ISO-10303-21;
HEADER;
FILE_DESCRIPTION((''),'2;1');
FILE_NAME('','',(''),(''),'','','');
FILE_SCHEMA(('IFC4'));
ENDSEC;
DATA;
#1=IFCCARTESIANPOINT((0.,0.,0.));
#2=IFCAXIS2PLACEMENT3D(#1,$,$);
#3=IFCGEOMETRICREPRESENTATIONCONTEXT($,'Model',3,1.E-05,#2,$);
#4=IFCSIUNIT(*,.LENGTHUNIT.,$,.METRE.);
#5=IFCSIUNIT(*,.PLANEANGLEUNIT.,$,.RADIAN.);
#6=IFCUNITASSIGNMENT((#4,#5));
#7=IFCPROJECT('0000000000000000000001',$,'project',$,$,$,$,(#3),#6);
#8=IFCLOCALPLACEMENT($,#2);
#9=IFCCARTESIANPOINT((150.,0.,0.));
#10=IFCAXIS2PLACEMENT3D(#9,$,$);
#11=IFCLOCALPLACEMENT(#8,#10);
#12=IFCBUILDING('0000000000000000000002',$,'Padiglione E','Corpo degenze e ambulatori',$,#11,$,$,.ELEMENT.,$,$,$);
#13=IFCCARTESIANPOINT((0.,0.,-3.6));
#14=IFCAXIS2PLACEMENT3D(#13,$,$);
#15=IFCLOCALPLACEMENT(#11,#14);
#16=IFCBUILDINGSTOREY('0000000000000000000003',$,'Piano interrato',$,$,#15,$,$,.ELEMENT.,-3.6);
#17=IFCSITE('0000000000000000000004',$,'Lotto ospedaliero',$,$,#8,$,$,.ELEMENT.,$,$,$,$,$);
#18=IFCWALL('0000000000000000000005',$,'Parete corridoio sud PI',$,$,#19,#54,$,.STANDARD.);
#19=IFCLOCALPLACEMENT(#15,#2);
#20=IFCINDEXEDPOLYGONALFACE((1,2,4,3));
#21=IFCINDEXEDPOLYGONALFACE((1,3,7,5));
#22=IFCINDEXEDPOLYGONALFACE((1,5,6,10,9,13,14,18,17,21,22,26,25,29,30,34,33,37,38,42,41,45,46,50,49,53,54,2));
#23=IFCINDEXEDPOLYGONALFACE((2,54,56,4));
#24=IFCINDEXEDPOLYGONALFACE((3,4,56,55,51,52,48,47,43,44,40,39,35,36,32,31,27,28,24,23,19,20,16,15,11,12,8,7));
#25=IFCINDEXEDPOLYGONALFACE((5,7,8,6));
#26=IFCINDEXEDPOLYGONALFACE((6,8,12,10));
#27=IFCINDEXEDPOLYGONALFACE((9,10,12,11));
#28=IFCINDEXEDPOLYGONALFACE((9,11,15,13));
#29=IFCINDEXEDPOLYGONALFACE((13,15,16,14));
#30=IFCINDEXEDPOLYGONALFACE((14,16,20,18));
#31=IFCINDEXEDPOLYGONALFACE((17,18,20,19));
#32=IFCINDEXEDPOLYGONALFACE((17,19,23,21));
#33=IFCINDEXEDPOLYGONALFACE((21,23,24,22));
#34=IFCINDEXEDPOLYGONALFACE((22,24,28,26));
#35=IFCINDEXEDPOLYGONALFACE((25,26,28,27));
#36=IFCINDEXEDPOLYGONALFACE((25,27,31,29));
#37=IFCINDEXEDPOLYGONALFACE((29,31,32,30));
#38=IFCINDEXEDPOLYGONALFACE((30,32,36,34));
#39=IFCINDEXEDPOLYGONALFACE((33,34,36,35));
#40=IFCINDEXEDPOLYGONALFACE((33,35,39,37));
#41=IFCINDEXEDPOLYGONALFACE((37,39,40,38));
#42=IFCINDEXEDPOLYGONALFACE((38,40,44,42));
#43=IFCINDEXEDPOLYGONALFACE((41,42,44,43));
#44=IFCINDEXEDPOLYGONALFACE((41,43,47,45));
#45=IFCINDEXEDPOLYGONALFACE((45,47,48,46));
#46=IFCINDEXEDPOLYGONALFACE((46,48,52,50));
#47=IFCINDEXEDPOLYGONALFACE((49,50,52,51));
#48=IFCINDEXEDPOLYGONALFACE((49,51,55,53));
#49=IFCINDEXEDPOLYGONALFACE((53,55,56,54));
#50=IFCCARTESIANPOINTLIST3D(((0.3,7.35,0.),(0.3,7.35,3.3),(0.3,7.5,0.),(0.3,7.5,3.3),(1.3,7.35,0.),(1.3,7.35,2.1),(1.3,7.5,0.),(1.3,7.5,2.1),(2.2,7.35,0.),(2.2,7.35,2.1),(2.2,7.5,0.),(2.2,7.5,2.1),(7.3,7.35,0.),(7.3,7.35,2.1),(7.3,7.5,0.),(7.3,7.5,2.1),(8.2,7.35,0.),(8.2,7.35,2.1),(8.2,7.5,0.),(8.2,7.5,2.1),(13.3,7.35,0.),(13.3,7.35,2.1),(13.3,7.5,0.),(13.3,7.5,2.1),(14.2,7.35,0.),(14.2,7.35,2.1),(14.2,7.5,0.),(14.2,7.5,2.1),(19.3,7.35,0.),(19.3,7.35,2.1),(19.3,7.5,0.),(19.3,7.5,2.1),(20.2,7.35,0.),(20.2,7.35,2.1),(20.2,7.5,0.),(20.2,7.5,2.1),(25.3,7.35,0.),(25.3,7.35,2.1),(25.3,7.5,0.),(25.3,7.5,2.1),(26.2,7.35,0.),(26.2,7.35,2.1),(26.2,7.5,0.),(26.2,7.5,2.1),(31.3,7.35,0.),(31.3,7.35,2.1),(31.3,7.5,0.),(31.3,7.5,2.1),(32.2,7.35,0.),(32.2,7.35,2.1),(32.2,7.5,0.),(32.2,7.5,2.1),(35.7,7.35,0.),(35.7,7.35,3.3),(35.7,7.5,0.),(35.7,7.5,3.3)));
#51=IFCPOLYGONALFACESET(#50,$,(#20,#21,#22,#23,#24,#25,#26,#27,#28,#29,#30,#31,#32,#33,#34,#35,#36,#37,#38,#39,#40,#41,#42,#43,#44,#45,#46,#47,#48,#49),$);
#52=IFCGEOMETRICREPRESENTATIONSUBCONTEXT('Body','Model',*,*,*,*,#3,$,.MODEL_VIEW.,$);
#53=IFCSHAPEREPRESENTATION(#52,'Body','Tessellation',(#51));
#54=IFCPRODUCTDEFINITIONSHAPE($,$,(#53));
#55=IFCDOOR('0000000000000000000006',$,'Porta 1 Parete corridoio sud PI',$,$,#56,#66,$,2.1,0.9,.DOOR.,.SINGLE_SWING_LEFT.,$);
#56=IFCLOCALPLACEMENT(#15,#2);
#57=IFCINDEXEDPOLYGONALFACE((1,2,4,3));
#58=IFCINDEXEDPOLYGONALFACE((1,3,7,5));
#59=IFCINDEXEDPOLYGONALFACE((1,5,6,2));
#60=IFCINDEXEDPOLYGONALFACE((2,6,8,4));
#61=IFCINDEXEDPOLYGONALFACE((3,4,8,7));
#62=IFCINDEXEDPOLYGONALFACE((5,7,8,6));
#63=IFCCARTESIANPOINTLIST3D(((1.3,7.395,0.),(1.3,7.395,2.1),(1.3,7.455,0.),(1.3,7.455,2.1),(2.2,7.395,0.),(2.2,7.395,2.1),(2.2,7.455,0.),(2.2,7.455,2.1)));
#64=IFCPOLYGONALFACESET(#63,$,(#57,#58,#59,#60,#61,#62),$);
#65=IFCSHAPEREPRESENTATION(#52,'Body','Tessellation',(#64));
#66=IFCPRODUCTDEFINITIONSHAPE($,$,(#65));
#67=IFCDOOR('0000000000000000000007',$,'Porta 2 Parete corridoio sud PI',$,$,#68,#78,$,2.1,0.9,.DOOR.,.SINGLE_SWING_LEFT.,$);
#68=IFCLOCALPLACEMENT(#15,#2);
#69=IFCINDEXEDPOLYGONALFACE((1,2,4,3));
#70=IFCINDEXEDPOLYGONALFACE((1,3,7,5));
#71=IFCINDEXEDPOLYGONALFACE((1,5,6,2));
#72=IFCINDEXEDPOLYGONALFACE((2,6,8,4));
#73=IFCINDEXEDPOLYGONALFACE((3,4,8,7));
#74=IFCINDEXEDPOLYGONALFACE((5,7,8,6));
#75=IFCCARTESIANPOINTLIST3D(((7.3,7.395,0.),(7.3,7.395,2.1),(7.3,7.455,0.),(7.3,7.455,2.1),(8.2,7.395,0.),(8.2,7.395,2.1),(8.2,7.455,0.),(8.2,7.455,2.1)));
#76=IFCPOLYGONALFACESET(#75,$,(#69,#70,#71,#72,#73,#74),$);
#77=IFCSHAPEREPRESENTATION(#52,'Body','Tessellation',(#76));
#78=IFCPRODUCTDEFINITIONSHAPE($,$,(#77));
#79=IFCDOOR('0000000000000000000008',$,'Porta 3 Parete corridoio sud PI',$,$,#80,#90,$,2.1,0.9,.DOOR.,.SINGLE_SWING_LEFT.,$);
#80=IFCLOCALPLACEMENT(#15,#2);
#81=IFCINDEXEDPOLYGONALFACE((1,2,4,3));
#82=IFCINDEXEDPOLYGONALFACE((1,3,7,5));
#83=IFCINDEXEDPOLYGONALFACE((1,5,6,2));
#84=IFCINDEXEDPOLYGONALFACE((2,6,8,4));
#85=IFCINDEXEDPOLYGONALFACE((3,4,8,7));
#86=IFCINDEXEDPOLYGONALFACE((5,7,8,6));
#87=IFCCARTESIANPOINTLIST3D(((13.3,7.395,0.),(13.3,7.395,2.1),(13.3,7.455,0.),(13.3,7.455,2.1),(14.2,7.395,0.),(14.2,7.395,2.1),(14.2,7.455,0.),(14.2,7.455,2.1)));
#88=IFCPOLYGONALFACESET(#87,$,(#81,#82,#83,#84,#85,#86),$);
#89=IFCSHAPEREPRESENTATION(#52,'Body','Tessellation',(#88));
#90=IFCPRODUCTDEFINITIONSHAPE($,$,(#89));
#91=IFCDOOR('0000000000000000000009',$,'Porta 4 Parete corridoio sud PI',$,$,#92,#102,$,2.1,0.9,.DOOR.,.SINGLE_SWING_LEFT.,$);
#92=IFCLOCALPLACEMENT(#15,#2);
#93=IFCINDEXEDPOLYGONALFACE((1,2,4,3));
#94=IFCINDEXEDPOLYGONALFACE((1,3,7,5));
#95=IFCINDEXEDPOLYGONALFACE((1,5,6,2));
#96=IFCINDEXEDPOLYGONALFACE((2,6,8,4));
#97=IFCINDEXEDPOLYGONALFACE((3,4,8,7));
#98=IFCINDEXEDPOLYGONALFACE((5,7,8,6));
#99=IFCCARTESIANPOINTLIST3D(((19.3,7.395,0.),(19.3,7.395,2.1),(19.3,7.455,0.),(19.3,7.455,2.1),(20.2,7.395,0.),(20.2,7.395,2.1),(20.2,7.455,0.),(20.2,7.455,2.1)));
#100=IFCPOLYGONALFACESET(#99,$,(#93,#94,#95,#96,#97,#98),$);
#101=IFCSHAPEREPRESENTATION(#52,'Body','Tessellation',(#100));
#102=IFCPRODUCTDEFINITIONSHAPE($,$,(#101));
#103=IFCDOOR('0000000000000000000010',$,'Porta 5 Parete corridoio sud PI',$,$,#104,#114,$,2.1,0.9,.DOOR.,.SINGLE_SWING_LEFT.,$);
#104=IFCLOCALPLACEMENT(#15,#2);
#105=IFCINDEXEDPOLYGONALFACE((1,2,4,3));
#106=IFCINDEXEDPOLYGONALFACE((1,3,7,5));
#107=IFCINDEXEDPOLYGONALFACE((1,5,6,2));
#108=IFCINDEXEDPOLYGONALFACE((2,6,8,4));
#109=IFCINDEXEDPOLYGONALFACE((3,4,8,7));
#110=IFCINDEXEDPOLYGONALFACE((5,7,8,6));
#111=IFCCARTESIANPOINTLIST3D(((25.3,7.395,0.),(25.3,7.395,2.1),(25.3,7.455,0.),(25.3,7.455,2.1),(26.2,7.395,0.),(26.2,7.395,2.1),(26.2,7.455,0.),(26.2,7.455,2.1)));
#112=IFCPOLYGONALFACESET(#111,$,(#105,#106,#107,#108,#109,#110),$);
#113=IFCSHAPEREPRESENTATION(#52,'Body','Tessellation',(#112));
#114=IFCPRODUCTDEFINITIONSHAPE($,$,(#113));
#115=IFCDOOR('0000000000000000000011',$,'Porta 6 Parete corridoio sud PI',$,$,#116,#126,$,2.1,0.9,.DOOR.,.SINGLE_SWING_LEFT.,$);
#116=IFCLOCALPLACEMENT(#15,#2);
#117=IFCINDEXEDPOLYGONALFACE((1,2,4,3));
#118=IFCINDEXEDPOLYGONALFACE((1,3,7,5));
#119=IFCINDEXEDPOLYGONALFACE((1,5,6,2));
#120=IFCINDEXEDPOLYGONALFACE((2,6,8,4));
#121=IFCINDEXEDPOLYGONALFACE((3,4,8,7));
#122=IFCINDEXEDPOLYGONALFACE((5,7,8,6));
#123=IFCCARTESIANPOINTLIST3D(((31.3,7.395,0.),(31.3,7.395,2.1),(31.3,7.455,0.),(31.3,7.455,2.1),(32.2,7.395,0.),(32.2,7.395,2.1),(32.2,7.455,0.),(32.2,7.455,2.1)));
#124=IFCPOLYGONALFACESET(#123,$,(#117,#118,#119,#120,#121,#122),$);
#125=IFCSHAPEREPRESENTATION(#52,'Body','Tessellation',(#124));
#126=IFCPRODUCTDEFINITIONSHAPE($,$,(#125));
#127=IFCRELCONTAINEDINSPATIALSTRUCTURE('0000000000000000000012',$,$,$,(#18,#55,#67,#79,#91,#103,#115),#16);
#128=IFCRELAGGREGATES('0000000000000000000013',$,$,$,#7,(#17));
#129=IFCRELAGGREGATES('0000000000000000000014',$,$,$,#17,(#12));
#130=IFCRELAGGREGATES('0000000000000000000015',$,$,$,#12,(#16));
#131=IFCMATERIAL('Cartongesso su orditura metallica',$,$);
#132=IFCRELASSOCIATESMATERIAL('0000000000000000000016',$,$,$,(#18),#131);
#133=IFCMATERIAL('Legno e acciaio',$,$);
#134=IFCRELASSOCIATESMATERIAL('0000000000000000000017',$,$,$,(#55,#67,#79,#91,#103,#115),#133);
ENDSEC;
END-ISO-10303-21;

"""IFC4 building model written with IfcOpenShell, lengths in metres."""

from ifc_helpers import new_model, si_unit, frame, frame_2d, origin, place, context, subcontext, project, spatial, rectangle, extrude, material, element, fill, save


model = new_model("IFC4")

# Units and contexts
model_context = context("Model", 3, precision=1e-05, world=origin())
body_context = subcontext(model_context, "Body", "Model", "MODEL_VIEW")
ifc_project = project(units=[si_unit("LENGTHUNIT", "METRE"), si_unit("PLANEANGLEUNIT", "RADIAN")], contexts=[model_context])

# Site, building, storey
site_placement = place(None, origin())
site = spatial("IfcSite", under=ifc_project, at=site_placement, Name="Lotto ospedaliero", CompositionType="ELEMENT")
building_placement = place(site_placement, frame((150.0, 0.0, 0.0)))
building = spatial("IfcBuilding", under=site, at=building_placement, Name="Padiglione E", Description="Corpo degenze e ambulatori", CompositionType="ELEMENT")
storey_placement = place(building_placement, frame((0.0, 0.0, -3.6)))
storey = spatial("IfcBuildingStorey", under=building, at=storey_placement, Name="Piano interrato", CompositionType="ELEMENT", Elevation=-3.6)

# Wall, openings, doors
ifc_material_1 = material(Name="Cartongesso su orditura metallica")
wall_1_placement = place(storey_placement, frame((0.3, 7.35, 0.0)))
wall_1 = element("IfcWall", 1, at=wall_1_placement, inside=storey, material=ifc_material_1, Name="Parete corridoio sud PI", PredefinedType="STANDARD", context=body_context, shape_type="SweptSolid", body=[
    extrude(rectangle(XDim=35.4, YDim=0.15, at=frame_2d((17.7, 0.075))), origin(), (0.0, 0.0, 1.0), 3.3),
])
opening_1_placement = place(wall_1_placement, frame((1.0, -0.1, 0.0)))
opening_1 = element("IfcOpeningElement", 2, at=opening_1_placement, cuts=wall_1, PredefinedType="OPENING", context=body_context, shape_type="SweptSolid", body=[
    extrude(rectangle(XDim=0.9, YDim=0.35, at=frame_2d((0.45, 0.175))), origin(), (0.0, 0.0, 1.0), 2.1),
])
opening_2_placement = place(wall_1_placement, frame((7.0, -0.1, 0.0)))
opening_2 = element("IfcOpeningElement", 3, at=opening_2_placement, cuts=wall_1, PredefinedType="OPENING", context=body_context, shape_type="SweptSolid", body=[
    extrude(rectangle(XDim=0.9, YDim=0.35, at=frame_2d((0.45, 0.175))), origin(), (0.0, 0.0, 1.0), 2.1),
])
opening_3_placement = place(wall_1_placement, frame((13.0, -0.1, 0.0)))
opening_3 = element("IfcOpeningElement", 4, at=opening_3_placement, cuts=wall_1, PredefinedType="OPENING", context=body_context, shape_type="SweptSolid", body=[
    extrude(rectangle(XDim=0.9, YDim=0.35, at=frame_2d((0.45, 0.175))), origin(), (0.0, 0.0, 1.0), 2.1),
])
opening_4_placement = place(wall_1_placement, frame((19.0, -0.1, 0.0)))
opening_4 = element("IfcOpeningElement", 5, at=opening_4_placement, cuts=wall_1, PredefinedType="OPENING", context=body_context, shape_type="SweptSolid", body=[
    extrude(rectangle(XDim=0.9, YDim=0.35, at=frame_2d((0.45, 0.175))), origin(), (0.0, 0.0, 1.0), 2.1),
])
opening_5_placement = place(wall_1_placement, frame((25.0, -0.1, 0.0)))
opening_5 = element("IfcOpeningElement", 6, at=opening_5_placement, cuts=wall_1, PredefinedType="OPENING", context=body_context, shape_type="SweptSolid", body=[
    extrude(rectangle(XDim=0.9, YDim=0.35, at=frame_2d((0.45, 0.175))), origin(), (0.0, 0.0, 1.0), 2.1),
])
opening_6_placement = place(wall_1_placement, frame((31.0, -0.1, 0.0)))
opening_6 = element("IfcOpeningElement", 7, at=opening_6_placement, cuts=wall_1, PredefinedType="OPENING", context=body_context, shape_type="SweptSolid", body=[
    extrude(rectangle(XDim=0.9, YDim=0.35, at=frame_2d((0.45, 0.175))), origin(), (0.0, 0.0, 1.0), 2.1),
])
ifc_material_2 = material(Name="Legno e acciaio")
door_1_placement = place(wall_1_placement, frame((1.0, 0.045, 0.0)))
door_1 = element("IfcDoor", 8, at=door_1_placement, inside=storey, material=ifc_material_2, Name="Porta 1 Parete corridoio sud PI", OperationType="SINGLE_SWING_LEFT", OverallHeight=2.1, OverallWidth=0.9, PredefinedType="DOOR", context=body_context, shape_type="SweptSolid", body=[
    extrude(rectangle(XDim=0.9, YDim=0.06, at=frame_2d((0.45, 0.03))), origin(), (0.0, 0.0, 1.0), 2.1),
])
fill(opening_1, door_1)
door_2_placement = place(wall_1_placement, frame((7.0, 0.045, 0.0)))
door_2 = element("IfcDoor", 9, at=door_2_placement, inside=storey, material=ifc_material_2, Name="Porta 2 Parete corridoio sud PI", OperationType="SINGLE_SWING_LEFT", OverallHeight=2.1, OverallWidth=0.9, PredefinedType="DOOR", context=body_context, shape_type="SweptSolid", body=[
    extrude(rectangle(XDim=0.9, YDim=0.06, at=frame_2d((0.45, 0.03))), origin(), (0.0, 0.0, 1.0), 2.1),
])
fill(opening_2, door_2)
door_3_placement = place(wall_1_placement, frame((13.0, 0.045, 0.0)))
door_3 = element("IfcDoor", 10, at=door_3_placement, inside=storey, material=ifc_material_2, Name="Porta 3 Parete corridoio sud PI", OperationType="SINGLE_SWING_LEFT", OverallHeight=2.1, OverallWidth=0.9, PredefinedType="DOOR", context=body_context, shape_type="SweptSolid", body=[
    extrude(rectangle(XDim=0.9, YDim=0.06, at=frame_2d((0.45, 0.03))), origin(), (0.0, 0.0, 1.0), 2.1),
])
fill(opening_3, door_3)
door_4_placement = place(wall_1_placement, frame((19.0, 0.045, 0.0)))
door_4 = element("IfcDoor", 11, at=door_4_placement, inside=storey, material=ifc_material_2, Name="Porta 4 Parete corridoio sud PI", OperationType="SINGLE_SWING_LEFT", OverallHeight=2.1, OverallWidth=0.9, PredefinedType="DOOR", context=body_context, shape_type="SweptSolid", body=[
    extrude(rectangle(XDim=0.9, YDim=0.06, at=frame_2d((0.45, 0.03))), origin(), (0.0, 0.0, 1.0), 2.1),
])
fill(opening_4, door_4)
door_5_placement = place(wall_1_placement, frame((25.0, 0.045, 0.0)))
door_5 = element("IfcDoor", 12, at=door_5_placement, inside=storey, material=ifc_material_2, Name="Porta 5 Parete corridoio sud PI", OperationType="SINGLE_SWING_LEFT", OverallHeight=2.1, OverallWidth=0.9, PredefinedType="DOOR", context=body_context, shape_type="SweptSolid", body=[
    extrude(rectangle(XDim=0.9, YDim=0.06, at=frame_2d((0.45, 0.03))), origin(), (0.0, 0.0, 1.0), 2.1),
])
fill(opening_5, door_5)
door_6_placement = place(wall_1_placement, frame((31.0, 0.045, 0.0)))
door_6 = element("IfcDoor", 13, at=door_6_placement, inside=storey, material=ifc_material_2, Name="Porta 6 Parete corridoio sud PI", OperationType="SINGLE_SWING_LEFT", OverallHeight=2.1, OverallWidth=0.9, PredefinedType="DOOR", context=body_context, shape_type="SweptSolid", body=[
    extrude(rectangle(XDim=0.9, YDim=0.06, at=frame_2d((0.45, 0.03))), origin(), (0.0, 0.0, 1.0), 2.1),
])
fill(opening_6, door_6)

save(model, "model.ifc")
